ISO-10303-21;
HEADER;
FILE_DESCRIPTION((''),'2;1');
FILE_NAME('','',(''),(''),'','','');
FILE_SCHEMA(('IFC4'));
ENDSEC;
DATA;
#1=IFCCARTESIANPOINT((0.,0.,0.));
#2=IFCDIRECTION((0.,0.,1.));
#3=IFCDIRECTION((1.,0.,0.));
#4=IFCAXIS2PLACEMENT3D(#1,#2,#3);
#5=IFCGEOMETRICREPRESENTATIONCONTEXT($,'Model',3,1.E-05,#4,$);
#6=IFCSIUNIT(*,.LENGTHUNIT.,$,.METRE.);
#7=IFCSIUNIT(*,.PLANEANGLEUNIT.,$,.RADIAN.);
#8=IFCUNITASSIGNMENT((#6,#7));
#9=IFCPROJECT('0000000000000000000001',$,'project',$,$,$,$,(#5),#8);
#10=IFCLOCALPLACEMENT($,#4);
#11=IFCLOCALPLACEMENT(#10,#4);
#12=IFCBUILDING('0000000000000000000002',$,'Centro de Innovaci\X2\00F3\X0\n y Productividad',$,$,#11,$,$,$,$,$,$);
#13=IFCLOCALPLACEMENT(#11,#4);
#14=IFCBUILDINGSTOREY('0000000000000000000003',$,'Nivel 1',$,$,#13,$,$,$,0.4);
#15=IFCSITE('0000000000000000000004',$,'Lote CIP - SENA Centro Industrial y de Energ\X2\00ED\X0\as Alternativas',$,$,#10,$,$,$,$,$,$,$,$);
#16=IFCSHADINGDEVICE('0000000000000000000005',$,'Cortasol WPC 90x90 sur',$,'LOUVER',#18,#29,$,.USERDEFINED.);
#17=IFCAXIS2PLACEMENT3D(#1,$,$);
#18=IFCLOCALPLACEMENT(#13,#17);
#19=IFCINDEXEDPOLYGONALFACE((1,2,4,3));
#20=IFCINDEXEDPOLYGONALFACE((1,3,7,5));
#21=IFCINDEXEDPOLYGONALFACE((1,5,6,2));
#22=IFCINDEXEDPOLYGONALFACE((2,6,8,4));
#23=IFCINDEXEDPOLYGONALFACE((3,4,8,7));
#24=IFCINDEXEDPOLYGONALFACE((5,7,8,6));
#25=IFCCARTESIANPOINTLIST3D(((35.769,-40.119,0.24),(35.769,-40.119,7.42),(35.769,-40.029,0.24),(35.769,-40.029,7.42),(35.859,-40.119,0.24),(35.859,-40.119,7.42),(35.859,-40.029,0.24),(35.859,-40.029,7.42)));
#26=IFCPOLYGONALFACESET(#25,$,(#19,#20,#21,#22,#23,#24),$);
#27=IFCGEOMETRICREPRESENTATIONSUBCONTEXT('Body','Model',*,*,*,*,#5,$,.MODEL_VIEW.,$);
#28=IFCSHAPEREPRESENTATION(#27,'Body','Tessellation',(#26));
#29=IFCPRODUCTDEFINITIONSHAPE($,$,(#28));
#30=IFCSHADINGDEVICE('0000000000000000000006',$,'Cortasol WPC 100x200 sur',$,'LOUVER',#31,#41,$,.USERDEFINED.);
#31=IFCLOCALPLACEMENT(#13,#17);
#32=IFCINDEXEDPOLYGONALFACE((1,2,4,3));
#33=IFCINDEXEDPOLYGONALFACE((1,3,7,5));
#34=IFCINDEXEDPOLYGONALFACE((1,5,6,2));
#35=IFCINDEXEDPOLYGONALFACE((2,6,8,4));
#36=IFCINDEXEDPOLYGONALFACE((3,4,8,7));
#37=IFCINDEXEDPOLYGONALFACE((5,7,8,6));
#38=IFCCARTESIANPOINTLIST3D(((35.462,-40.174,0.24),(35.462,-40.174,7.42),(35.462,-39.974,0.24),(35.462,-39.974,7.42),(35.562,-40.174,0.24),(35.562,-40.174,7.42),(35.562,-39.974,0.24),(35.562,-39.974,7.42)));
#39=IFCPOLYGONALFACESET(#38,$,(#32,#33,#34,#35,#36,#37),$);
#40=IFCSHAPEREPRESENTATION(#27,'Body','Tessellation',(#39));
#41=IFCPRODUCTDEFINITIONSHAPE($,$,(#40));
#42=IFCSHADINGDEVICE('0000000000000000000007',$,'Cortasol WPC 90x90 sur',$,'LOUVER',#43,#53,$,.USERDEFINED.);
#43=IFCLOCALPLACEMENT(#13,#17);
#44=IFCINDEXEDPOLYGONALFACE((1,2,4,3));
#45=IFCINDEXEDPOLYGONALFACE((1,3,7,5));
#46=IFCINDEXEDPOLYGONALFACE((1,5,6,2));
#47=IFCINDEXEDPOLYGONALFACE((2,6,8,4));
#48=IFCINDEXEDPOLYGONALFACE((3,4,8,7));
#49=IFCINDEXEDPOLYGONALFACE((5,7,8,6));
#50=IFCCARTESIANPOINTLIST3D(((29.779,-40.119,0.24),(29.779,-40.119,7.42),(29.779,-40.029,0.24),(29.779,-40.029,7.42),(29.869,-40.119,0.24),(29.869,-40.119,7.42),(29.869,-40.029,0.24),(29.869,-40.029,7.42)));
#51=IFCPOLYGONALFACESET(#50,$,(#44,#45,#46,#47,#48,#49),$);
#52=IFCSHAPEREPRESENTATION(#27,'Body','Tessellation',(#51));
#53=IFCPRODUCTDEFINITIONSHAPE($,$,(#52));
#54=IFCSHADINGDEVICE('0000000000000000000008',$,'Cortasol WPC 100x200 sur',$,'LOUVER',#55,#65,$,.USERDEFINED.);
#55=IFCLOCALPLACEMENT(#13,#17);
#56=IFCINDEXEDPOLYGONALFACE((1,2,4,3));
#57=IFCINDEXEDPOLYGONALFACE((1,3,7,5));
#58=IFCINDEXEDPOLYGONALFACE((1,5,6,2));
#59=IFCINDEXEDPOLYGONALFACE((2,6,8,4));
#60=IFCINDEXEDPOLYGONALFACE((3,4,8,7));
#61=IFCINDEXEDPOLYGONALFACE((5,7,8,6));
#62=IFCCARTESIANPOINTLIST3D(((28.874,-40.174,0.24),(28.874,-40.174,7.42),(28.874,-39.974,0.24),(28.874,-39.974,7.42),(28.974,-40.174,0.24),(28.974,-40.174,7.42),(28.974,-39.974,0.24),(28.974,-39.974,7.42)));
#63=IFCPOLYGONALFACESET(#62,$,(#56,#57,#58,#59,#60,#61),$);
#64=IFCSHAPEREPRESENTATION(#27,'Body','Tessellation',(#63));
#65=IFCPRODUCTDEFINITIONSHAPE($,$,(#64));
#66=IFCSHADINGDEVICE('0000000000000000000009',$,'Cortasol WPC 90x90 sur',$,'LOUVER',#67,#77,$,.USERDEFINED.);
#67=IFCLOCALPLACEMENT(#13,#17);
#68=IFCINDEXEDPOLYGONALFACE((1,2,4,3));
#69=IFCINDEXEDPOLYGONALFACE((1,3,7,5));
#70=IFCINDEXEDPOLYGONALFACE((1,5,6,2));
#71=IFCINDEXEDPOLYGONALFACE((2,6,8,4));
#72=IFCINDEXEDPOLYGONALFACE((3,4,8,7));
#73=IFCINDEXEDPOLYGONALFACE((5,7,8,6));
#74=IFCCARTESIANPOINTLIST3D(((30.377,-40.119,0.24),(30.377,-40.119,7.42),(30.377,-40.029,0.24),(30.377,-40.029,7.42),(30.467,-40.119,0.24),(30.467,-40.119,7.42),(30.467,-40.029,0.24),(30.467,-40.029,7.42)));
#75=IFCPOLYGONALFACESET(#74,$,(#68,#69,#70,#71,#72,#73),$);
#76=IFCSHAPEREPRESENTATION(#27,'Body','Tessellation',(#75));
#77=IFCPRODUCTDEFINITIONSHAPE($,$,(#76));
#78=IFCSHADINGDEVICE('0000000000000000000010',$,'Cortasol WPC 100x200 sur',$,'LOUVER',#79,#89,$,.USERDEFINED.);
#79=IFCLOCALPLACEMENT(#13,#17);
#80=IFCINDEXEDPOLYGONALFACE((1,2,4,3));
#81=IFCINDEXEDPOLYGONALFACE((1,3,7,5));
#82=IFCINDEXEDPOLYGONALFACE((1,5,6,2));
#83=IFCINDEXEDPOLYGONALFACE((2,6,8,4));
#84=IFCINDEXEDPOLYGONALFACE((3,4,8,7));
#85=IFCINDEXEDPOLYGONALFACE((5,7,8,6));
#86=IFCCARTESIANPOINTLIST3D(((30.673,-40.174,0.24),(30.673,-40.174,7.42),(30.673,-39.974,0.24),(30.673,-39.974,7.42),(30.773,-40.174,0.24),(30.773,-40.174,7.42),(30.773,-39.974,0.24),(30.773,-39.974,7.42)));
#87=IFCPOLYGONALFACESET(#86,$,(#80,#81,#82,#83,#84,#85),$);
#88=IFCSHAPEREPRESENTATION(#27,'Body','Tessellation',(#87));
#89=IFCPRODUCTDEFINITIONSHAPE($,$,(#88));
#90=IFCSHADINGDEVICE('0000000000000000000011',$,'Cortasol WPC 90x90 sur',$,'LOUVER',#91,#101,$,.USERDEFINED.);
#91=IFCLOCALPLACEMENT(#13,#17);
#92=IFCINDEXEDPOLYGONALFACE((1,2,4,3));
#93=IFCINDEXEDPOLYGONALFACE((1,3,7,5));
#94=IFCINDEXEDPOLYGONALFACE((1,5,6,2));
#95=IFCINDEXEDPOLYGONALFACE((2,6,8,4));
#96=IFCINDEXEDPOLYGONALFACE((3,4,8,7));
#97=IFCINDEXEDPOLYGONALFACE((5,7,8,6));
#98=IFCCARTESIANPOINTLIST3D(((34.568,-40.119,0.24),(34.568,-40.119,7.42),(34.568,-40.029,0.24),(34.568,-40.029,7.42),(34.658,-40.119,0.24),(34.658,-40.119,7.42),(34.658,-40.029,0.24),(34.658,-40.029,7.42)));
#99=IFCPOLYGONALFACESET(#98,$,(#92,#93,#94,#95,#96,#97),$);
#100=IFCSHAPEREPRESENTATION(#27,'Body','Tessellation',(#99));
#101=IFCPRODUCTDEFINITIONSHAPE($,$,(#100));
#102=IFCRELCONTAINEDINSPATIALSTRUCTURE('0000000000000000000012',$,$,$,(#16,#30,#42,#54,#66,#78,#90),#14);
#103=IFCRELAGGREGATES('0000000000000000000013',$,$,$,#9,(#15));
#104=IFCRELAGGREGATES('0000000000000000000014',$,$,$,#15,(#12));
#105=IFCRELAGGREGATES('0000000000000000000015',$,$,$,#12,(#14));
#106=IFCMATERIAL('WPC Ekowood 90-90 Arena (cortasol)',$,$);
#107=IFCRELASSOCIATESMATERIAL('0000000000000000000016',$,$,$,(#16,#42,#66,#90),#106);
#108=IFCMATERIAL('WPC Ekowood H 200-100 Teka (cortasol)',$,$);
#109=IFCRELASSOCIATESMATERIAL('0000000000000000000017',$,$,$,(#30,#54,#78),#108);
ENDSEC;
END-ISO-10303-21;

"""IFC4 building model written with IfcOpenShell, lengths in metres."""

from ifc_helpers import new_model, si_unit, frame, origin_with_axes, place, context, subcontext, project, spatial, polyline, outline, extrude, material, element, save


model = new_model("IFC4")

# Units and contexts
model_context = context("Model", 3, precision=1e-05, world=origin_with_axes())
body_context = subcontext(model_context, "Body", "Model", "MODEL_VIEW")
ifc_project = project(units=[si_unit("LENGTHUNIT", "METRE"), si_unit("PLANEANGLEUNIT", "RADIAN")], contexts=[model_context])

# Site, building, storey
site_placement = place(None, origin_with_axes())
site = spatial("IfcSite", under=ifc_project, at=site_placement, Name="Lote CIP - SENA Centro Industrial y de Energías Alternativas")
building_placement = place(site_placement, origin_with_axes())
building = spatial("IfcBuilding", under=site, at=building_placement, Name="Centro de Innovación y Productividad")
storey_placement = place(building_placement, origin_with_axes())
storey = spatial("IfcBuildingStorey", under=building, at=storey_placement, Name="Nivel 1", Elevation=0.4)

# Shading devices
ifc_material_1 = material(Name="WPC Ekowood 90-90 Arena (cortasol)")
ifc_material_2 = material(Name="WPC Ekowood H 200-100 Teka (cortasol)")
shading_device_1_placement = place(storey_placement, origin_with_axes())
element("IfcShadingDevice", 1, at=shading_device_1_placement, inside=storey, material=ifc_material_1, Name="Cortasol WPC 90x90 sur", ObjectType="LOUVER", PredefinedType="USERDEFINED", context=body_context, shape_type="SweptSolid", body=[
    extrude(outline(polyline([(35.769, -40.119), (35.769, -40.029), (35.859, -40.029), (35.859, -40.119), (35.769, -40.119)])), frame((0.0, 0.0, 0.24)), (0.0, 0.0, 1.0), 7.18),
])
shading_device_2_placement = place(storey_placement, origin_with_axes())
element("IfcShadingDevice", 2, at=shading_device_2_placement, inside=storey, material=ifc_material_2, Name="Cortasol WPC 100x200 sur", ObjectType="LOUVER", PredefinedType="USERDEFINED", context=body_context, shape_type="SweptSolid", body=[
    extrude(outline(polyline([(35.462, -40.174), (35.462, -39.974), (35.562, -39.974), (35.562, -40.174), (35.462, -40.174)])), frame((0.0, 0.0, 0.24)), (0.0, 0.0, 1.0), 7.18),
])
shading_device_3_placement = place(storey_placement, origin_with_axes())
element("IfcShadingDevice", 3, at=shading_device_3_placement, inside=storey, material=ifc_material_1, Name="Cortasol WPC 90x90 sur", ObjectType="LOUVER", PredefinedType="USERDEFINED", context=body_context, shape_type="SweptSolid", body=[
    extrude(outline(polyline([(29.779, -40.119), (29.779, -40.029), (29.869, -40.029), (29.869, -40.119), (29.779, -40.119)])), frame((0.0, 0.0, 0.24)), (0.0, 0.0, 1.0), 7.18),
])
shading_device_4_placement = place(storey_placement, origin_with_axes())
element("IfcShadingDevice", 4, at=shading_device_4_placement, inside=storey, material=ifc_material_2, Name="Cortasol WPC 100x200 sur", ObjectType="LOUVER", PredefinedType="USERDEFINED", context=body_context, shape_type="SweptSolid", body=[
    extrude(outline(polyline([(28.874, -40.174), (28.874, -39.974), (28.974, -39.974), (28.974, -40.174), (28.874, -40.174)])), frame((0.0, 0.0, 0.24)), (0.0, 0.0, 1.0), 7.18),
])
shading_device_5_placement = place(storey_placement, origin_with_axes())
element("IfcShadingDevice", 5, at=shading_device_5_placement, inside=storey, material=ifc_material_1, Name="Cortasol WPC 90x90 sur", ObjectType="LOUVER", PredefinedType="USERDEFINED", context=body_context, shape_type="SweptSolid", body=[
    extrude(outline(polyline([(30.377, -40.119), (30.377, -40.029), (30.467, -40.029), (30.467, -40.119), (30.377, -40.119)])), frame((0.0, 0.0, 0.24)), (0.0, 0.0, 1.0), 7.18),
])
shading_device_6_placement = place(storey_placement, origin_with_axes())
element("IfcShadingDevice", 6, at=shading_device_6_placement, inside=storey, material=ifc_material_2, Name="Cortasol WPC 100x200 sur", ObjectType="LOUVER", PredefinedType="USERDEFINED", context=body_context, shape_type="SweptSolid", body=[
    extrude(outline(polyline([(30.673, -40.174), (30.673, -39.974), (30.773, -39.974), (30.773, -40.174), (30.673, -40.174)])), frame((0.0, 0.0, 0.24)), (0.0, 0.0, 1.0), 7.18),
])
shading_device_7_placement = place(storey_placement, origin_with_axes())
element("IfcShadingDevice", 7, at=shading_device_7_placement, inside=storey, material=ifc_material_1, Name="Cortasol WPC 90x90 sur", ObjectType="LOUVER", PredefinedType="USERDEFINED", context=body_context, shape_type="SweptSolid", body=[
    extrude(outline(polyline([(34.568, -40.119), (34.568, -40.029), (34.658, -40.029), (34.658, -40.119), (34.568, -40.119)])), frame((0.0, 0.0, 0.24)), (0.0, 0.0, 1.0), 7.18),
])

save(model, "model.ifc")
